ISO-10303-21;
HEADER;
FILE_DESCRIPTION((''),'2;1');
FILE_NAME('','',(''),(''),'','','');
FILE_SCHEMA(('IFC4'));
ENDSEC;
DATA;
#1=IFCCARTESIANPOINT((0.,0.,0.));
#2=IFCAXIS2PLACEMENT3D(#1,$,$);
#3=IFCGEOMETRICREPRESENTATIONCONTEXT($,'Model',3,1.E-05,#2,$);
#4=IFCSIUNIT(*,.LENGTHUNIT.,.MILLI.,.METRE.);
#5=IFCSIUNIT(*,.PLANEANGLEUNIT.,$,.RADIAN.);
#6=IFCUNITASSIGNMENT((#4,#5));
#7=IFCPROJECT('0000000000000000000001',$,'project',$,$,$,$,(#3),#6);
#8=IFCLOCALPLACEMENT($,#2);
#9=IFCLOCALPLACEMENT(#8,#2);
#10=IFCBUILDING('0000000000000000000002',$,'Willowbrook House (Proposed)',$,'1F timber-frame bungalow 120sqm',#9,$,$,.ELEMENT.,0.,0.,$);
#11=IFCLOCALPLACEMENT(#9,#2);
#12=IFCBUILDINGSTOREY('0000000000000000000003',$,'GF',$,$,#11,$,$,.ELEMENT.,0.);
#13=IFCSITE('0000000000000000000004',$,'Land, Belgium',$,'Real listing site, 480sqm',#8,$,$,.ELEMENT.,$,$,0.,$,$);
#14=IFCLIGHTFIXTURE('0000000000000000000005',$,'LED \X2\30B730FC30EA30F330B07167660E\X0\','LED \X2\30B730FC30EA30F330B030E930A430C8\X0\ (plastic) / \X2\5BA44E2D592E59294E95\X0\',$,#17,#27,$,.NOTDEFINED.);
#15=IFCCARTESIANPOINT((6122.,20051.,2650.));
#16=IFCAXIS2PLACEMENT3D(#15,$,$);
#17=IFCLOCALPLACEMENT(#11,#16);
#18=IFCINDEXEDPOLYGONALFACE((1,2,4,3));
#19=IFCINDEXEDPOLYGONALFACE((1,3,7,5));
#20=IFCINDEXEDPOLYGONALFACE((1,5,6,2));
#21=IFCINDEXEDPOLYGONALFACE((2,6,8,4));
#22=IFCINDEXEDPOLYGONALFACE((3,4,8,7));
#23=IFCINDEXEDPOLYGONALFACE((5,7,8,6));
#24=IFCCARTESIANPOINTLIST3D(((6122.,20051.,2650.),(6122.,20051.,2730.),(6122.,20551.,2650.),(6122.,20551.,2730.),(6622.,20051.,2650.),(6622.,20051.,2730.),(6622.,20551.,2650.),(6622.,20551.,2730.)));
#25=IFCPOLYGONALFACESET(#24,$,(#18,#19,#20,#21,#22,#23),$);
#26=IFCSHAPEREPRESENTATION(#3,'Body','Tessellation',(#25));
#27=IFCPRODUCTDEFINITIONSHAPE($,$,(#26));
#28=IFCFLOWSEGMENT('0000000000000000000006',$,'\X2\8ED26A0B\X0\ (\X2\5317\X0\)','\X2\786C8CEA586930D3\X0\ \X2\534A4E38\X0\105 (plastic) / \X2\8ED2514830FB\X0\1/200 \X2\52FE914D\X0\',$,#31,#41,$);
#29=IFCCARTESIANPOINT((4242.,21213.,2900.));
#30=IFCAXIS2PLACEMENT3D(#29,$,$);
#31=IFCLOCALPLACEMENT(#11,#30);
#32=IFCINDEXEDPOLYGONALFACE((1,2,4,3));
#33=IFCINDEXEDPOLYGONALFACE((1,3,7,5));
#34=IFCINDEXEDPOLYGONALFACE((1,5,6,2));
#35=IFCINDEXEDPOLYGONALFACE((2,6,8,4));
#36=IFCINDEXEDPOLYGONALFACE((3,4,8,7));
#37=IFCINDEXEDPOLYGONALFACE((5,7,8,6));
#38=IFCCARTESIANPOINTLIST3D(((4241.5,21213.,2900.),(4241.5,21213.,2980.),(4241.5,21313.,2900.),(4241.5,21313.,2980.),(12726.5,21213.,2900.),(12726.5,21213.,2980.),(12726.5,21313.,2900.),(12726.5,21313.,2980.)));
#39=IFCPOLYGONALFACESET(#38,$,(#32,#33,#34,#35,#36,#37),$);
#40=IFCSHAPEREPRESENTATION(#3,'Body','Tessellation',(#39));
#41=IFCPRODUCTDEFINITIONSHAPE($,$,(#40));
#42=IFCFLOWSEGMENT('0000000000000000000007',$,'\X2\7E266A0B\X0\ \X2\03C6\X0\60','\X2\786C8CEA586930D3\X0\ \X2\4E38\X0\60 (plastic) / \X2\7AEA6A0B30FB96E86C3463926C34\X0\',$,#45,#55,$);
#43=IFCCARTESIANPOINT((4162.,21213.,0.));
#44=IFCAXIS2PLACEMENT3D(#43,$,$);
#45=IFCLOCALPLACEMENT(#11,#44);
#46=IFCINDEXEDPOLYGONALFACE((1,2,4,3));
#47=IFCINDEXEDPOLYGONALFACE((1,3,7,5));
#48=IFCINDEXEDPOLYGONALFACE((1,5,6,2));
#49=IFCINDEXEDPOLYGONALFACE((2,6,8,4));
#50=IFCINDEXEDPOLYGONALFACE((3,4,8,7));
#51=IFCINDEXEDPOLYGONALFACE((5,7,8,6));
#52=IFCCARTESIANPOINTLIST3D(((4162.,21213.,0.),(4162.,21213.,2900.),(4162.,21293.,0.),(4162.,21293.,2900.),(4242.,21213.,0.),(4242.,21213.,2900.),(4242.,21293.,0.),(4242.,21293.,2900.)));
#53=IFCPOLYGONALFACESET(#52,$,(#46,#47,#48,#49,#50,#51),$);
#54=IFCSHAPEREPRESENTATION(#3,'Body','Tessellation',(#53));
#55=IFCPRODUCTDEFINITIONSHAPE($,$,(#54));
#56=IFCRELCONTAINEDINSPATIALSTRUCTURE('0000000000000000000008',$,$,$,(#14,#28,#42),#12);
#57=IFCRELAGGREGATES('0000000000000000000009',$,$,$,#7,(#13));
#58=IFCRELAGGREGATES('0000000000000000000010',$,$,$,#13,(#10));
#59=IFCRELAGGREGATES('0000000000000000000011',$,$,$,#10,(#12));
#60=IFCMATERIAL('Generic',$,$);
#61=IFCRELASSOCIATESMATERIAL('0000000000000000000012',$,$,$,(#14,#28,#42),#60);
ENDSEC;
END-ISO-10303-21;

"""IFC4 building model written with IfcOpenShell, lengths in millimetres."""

from ifc_helpers import new_model, si_unit, frame, frame_2d, origin, place, context, project, spatial, rectangle, extrude, material, element, save


model = new_model("IFC4")

# Units and contexts
model_context = context("Model", 3, precision=1e-05, world=origin())
ifc_project = project(units=[si_unit("LENGTHUNIT", "METRE", prefix="MILLI"), si_unit("PLANEANGLEUNIT", "RADIAN")], contexts=[model_context])

# Site, building, storey
site_placement = place(None, origin())
site = spatial("IfcSite", under=ifc_project, at=site_placement, Name="Land, Belgium", ObjectType="Real listing site, 480sqm", CompositionType="ELEMENT", RefElevation=0.0)
building_placement = place(site_placement, origin())
building = spatial("IfcBuilding", under=site, at=building_placement, Name="Willowbrook House (Proposed)", ObjectType="1F timber-frame bungalow 120sqm", CompositionType="ELEMENT", ElevationOfRefHeight=0.0, ElevationOfTerrain=0.0)
storey_placement = place(building_placement, origin())
storey = spatial("IfcBuildingStorey", under=building, at=storey_placement, Name="GF", CompositionType="ELEMENT", Elevation=0.0)

# Shared definitions
ifc_material_1 = material(Name="Generic")

# Light fixture
light_fixture_placement = place(storey_placement, frame((6122.0, 20051.0, 2650.0)))
element("IfcLightFixture", 1, at=light_fixture_placement, inside=storey, material=ifc_material_1, Name="LED シーリング照明", Description="LED シーリングライト (plastic) / 室中央天井", PredefinedType="NOTDEFINED", context=model_context, shape_type="SweptSolid", body=[
    extrude(rectangle(XDim=500.0, YDim=500.0, at=frame_2d((250.0, 250.0))), frame((6122.0, 20051.0, 2650.0)), (0.0, 0.0, 1.0), 80.0),
])

# Flow segments
flow_segment_1_placement = place(storey_placement, frame((4242.0, 21213.0, 2900.0)))
element("IfcFlowSegment", 2, at=flow_segment_1_placement, inside=storey, material=ifc_material_1, Name="軒樋 (北)", Description="硬質塩ビ 半丸105 (plastic) / 軒先・1/200 勾配", context=model_context, shape_type="SweptSolid", body=[
    extrude(rectangle(XDim=8485.0, YDim=100.0, at=frame_2d((4242.0, 50.0))), frame((4242.0, 21213.0, 2900.0)), (0.0, 0.0, 1.0), 80.0),
])
flow_segment_2_placement = place(storey_placement, frame((4162.0, 21213.0, 0.0)))
element("IfcFlowSegment", 3, at=flow_segment_2_placement, inside=storey, material=ifc_material_1, Name="縦樋 φ60", Description="硬質塩ビ 丸60 (plastic) / 竪樋・雨水排水", context=model_context, shape_type="SweptSolid", body=[
    extrude(rectangle(XDim=80.0, YDim=80.0, at=frame_2d((40.0, 40.0))), frame((4162.0, 21213.0, 0.0)), (0.0, 0.0, 1.0), 2900.0),
])

save(model, "model.ifc")
